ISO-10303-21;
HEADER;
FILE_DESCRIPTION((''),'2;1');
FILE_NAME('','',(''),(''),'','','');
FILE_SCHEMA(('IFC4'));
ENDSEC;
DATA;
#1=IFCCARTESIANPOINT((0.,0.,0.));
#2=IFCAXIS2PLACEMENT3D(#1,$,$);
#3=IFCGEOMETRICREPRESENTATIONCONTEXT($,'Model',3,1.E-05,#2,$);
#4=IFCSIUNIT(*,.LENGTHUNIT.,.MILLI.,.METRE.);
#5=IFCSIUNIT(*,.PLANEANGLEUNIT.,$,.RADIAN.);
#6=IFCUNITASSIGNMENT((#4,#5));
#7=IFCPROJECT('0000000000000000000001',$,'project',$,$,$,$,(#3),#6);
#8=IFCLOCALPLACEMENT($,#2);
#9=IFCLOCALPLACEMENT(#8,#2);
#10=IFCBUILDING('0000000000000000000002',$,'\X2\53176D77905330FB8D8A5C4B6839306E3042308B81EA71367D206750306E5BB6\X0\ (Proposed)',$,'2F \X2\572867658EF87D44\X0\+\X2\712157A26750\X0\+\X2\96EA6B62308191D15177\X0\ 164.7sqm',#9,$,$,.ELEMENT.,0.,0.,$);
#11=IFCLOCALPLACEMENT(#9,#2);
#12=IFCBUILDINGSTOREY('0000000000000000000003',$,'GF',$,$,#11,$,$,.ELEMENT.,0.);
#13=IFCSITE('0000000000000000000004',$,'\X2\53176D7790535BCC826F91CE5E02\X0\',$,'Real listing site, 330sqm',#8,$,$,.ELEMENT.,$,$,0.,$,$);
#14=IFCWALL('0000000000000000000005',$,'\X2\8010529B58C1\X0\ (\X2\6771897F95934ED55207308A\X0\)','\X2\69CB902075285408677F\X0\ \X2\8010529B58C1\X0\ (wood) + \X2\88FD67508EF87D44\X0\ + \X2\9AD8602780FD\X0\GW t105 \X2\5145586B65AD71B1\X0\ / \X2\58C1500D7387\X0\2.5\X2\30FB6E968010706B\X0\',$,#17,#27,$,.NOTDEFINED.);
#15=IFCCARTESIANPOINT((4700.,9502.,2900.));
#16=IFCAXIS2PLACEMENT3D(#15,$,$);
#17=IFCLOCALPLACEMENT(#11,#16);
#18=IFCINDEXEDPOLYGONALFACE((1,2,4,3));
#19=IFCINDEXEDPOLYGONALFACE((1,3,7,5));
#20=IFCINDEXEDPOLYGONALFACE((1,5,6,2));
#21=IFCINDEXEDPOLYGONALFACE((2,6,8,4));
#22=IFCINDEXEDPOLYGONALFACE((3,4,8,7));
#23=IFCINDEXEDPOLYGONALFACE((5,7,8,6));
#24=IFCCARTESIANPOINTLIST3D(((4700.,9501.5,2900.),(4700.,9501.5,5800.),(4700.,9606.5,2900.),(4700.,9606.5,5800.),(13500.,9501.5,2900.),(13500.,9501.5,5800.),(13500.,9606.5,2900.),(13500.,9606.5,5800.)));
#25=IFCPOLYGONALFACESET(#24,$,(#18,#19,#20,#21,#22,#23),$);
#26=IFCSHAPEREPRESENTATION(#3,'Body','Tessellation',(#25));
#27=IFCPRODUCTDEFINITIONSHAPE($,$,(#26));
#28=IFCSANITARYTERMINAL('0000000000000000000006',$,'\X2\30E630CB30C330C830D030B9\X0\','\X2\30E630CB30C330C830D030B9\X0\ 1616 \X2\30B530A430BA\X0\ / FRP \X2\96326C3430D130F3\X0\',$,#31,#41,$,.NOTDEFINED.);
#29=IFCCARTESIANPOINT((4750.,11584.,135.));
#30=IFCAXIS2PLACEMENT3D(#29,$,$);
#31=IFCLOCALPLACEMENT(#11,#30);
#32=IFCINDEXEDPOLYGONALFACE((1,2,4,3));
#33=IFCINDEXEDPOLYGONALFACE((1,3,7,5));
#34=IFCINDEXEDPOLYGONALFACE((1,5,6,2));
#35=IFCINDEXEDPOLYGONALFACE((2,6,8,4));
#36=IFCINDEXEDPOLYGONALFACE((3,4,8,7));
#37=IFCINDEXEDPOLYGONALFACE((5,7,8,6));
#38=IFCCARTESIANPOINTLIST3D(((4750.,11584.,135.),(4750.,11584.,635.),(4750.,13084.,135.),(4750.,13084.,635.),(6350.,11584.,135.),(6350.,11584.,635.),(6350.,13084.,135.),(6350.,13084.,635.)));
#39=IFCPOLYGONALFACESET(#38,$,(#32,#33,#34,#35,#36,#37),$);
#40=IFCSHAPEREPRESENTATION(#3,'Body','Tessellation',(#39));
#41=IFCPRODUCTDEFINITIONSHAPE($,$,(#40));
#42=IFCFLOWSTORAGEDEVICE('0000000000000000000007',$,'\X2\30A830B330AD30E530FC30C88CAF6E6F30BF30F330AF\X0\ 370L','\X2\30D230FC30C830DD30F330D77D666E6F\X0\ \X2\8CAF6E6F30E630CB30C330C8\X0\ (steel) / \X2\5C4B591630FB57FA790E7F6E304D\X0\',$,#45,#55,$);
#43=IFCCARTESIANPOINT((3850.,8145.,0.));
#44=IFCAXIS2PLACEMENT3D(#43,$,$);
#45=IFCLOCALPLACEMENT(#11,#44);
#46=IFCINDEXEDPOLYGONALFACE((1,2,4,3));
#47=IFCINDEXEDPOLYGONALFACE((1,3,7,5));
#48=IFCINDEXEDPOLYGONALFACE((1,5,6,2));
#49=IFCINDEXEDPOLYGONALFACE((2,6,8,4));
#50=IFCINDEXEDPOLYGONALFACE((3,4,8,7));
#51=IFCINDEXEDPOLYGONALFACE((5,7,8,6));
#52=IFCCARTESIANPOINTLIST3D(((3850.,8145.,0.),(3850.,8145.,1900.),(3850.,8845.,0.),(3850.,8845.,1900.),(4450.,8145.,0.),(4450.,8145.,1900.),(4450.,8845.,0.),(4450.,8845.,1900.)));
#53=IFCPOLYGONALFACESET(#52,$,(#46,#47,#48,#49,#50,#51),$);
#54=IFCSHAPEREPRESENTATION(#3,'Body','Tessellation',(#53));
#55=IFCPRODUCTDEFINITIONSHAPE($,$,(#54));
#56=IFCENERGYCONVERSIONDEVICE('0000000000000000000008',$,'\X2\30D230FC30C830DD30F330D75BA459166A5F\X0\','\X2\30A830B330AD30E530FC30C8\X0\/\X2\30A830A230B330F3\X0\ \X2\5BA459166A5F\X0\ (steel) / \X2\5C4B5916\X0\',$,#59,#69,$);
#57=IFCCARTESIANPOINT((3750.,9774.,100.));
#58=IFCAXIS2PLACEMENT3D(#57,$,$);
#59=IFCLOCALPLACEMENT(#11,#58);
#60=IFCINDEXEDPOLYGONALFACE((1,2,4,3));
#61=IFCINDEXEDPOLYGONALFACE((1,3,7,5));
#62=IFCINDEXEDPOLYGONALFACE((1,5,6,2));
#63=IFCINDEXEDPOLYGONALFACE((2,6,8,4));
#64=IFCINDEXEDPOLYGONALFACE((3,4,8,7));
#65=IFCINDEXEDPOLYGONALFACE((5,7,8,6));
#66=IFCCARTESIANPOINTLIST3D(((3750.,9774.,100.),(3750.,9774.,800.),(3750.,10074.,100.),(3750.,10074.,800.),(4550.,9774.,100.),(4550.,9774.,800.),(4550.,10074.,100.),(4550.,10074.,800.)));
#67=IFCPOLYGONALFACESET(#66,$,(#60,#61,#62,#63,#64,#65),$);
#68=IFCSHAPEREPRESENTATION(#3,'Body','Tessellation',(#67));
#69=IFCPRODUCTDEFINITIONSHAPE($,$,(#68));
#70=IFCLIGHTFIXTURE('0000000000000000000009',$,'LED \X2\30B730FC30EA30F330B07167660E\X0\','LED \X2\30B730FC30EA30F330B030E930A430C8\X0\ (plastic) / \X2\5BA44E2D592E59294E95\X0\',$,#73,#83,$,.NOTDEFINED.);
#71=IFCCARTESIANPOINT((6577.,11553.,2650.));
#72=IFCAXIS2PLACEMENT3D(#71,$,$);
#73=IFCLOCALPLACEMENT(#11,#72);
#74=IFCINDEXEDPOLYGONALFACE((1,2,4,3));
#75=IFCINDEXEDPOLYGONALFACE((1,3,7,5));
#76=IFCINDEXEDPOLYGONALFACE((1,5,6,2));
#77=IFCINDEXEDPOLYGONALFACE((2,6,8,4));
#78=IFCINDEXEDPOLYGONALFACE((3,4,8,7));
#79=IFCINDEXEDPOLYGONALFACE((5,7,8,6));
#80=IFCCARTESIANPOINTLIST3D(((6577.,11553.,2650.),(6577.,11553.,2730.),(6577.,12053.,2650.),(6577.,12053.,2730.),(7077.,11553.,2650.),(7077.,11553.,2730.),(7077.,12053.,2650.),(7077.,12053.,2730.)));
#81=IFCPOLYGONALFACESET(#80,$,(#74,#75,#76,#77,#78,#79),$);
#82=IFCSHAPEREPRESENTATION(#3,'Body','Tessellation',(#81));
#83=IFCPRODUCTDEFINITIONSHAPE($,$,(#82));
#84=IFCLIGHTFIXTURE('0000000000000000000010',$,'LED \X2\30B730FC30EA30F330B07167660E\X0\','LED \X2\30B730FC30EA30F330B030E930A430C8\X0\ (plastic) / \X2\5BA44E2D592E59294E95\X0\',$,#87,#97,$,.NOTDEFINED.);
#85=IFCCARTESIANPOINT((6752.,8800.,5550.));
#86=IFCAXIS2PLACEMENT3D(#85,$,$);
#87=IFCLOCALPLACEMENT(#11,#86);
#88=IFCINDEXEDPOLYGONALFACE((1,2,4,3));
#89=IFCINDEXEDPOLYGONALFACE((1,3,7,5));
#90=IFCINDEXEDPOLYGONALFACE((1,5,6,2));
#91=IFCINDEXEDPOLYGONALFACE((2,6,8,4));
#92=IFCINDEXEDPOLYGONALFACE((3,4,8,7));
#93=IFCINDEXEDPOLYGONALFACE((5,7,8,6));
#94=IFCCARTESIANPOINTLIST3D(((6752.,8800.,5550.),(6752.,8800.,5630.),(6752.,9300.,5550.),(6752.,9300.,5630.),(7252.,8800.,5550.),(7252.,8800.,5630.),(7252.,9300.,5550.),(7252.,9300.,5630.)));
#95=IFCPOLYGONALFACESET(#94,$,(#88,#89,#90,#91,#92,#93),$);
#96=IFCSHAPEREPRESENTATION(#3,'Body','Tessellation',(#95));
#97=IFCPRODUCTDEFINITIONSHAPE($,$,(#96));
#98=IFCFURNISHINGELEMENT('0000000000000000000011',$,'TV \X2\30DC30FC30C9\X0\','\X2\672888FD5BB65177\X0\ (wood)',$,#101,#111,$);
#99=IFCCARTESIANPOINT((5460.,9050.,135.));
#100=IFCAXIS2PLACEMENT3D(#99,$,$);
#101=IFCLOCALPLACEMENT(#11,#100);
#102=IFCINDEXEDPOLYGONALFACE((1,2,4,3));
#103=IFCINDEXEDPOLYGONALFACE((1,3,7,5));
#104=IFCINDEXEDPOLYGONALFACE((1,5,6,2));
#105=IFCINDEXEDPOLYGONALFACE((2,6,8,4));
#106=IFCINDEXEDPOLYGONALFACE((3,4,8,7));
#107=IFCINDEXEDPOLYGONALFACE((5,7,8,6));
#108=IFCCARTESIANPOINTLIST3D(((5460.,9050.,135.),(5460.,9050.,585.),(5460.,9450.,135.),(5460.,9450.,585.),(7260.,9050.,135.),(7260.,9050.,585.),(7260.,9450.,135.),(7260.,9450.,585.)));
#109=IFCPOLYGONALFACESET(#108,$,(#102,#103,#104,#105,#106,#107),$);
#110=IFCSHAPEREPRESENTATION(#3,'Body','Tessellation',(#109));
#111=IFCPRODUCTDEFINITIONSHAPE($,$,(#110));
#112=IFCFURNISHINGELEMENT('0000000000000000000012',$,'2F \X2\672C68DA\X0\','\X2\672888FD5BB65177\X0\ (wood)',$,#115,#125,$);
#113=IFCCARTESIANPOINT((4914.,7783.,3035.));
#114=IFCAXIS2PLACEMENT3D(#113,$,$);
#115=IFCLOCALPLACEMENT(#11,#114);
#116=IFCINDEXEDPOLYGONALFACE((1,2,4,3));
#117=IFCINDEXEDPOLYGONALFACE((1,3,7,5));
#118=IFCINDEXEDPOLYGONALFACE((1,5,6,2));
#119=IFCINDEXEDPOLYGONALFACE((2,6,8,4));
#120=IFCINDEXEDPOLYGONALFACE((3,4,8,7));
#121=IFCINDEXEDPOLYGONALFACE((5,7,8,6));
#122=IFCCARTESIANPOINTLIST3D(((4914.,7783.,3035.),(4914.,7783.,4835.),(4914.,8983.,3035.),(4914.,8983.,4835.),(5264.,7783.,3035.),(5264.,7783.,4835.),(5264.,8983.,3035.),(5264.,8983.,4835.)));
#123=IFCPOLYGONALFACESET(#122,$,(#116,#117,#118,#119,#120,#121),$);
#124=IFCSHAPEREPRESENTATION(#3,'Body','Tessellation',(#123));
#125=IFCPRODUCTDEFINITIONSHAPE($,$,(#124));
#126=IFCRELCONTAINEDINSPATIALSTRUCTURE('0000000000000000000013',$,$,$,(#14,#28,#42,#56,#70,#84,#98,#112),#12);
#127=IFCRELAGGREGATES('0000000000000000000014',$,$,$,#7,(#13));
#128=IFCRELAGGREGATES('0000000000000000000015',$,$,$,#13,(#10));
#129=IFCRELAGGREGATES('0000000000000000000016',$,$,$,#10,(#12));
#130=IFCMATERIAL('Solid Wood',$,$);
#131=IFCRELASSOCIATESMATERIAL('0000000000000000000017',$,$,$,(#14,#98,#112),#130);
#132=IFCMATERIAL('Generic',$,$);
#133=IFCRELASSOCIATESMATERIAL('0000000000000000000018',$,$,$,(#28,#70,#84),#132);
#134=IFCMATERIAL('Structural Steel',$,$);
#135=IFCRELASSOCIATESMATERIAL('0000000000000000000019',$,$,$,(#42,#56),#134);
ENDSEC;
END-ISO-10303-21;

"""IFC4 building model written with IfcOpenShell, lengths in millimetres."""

from ifc_helpers import new_model, si_unit, frame, frame_2d, origin, place, context, project, spatial, rectangle, extrude, material, element, save


model = new_model("IFC4")

# Units and contexts
model_context = context("Model", 3, precision=1e-05, world=origin())
ifc_project = project(units=[si_unit("LENGTHUNIT", "METRE", prefix="MILLI"), si_unit("PLANEANGLEUNIT", "RADIAN")], contexts=[model_context])

# Site, building, storey
site_placement = place(None, origin())
site = spatial("IfcSite", under=ifc_project, at=site_placement, Name="北海道富良野市", ObjectType="Real listing site, 330sqm", CompositionType="ELEMENT", RefElevation=0.0)
building_placement = place(site_placement, origin())
building = spatial("IfcBuilding", under=site, at=building_placement, Name="北海道・越屋根のある自然素材の家 (Proposed)", ObjectType="2F 在来軸組+無垢材+雪止め金具 164.7sqm", CompositionType="ELEMENT", ElevationOfRefHeight=0.0, ElevationOfTerrain=0.0)
storey_placement = place(building_placement, origin())
storey = spatial("IfcBuildingStorey", under=building, at=storey_placement, Name="GF", CompositionType="ELEMENT", Elevation=0.0)

# Shared definitions
ifc_material_1 = material(Name="Solid Wood")

# Wall
wall_1_placement = place(storey_placement, frame((4700.0, 9502.0, 2900.0)))
element("IfcWall", 1, at=wall_1_placement, inside=storey, material=ifc_material_1, Name="耐力壁 (東西間仕切り)", Description="構造用合板 耐力壁 (wood) + 製材軸組 + 高性能GW t105 充填断熱 / 壁倍率2.5・準耐火", PredefinedType="NOTDEFINED", context=model_context, shape_type="SweptSolid", body=[
    extrude(rectangle(XDim=8800.0, YDim=105.0, at=frame_2d((4400.0, 52.0))), frame((4700.0, 9502.0, 2900.0)), (0.0, 0.0, 1.0), 2900.0),
])

# Sanitary terminal
ifc_material_2 = material(Name="Generic")
sanitary_terminal_placement = place(storey_placement, frame((4750.0, 11584.0, 135.0)))
element("IfcSanitaryTerminal", 2, at=sanitary_terminal_placement, inside=storey, material=ifc_material_2, Name="ユニットバス", Description="ユニットバス 1616 サイズ / FRP 防水パン", PredefinedType="NOTDEFINED", context=model_context, shape_type="SweptSolid", body=[
    extrude(rectangle(XDim=1600.0, YDim=1500.0, at=frame_2d((800.0, 750.0))), frame((4750.0, 11584.0, 135.0)), (0.0, 0.0, 1.0), 500.0),
])

# Flow storage device
ifc_material_3 = material(Name="Structural Steel")
flow_storage_device_placement = place(storey_placement, frame((3850.0, 8145.0, 0.0)))
element("IfcFlowStorageDevice", 3, at=flow_storage_device_placement, inside=storey, material=ifc_material_3, Name="エコキュート貯湯タンク 370L", Description="ヒートポンプ給湯 貯湯ユニット (steel) / 屋外・基礎置き", context=model_context, shape_type="SweptSolid", body=[
    extrude(rectangle(XDim=600.0, YDim=700.0, at=frame_2d((300.0, 350.0))), frame((3850.0, 8145.0, 0.0)), (0.0, 0.0, 1.0), 1900.0),
])

# Energy conversion device
energy_conversion_device_placement = place(storey_placement, frame((3750.0, 9774.0, 100.0)))
element("IfcEnergyConversionDevice", 4, at=energy_conversion_device_placement, inside=storey, material=ifc_material_3, Name="ヒートポンプ室外機", Description="エコキュート/エアコン 室外機 (steel) / 屋外", context=model_context, shape_type="SweptSolid", body=[
    extrude(rectangle(XDim=800.0, YDim=300.0, at=frame_2d((400.0, 150.0))), frame((3750.0, 9774.0, 100.0)), (0.0, 0.0, 1.0), 700.0),
])

# Light fixtures
light_fixture_1_placement = place(storey_placement, frame((6577.0, 11553.0, 2650.0)))
element("IfcLightFixture", 5, at=light_fixture_1_placement, inside=storey, material=ifc_material_2, Name="LED シーリング照明", Description="LED シーリングライト (plastic) / 室中央天井", PredefinedType="NOTDEFINED", context=model_context, shape_type="SweptSolid", body=[
    extrude(rectangle(XDim=500.0, YDim=500.0, at=frame_2d((250.0, 250.0))), frame((6577.0, 11553.0, 2650.0)), (0.0, 0.0, 1.0), 80.0),
])
light_fixture_2_placement = place(storey_placement, frame((6752.0, 8800.0, 5550.0)))
element("IfcLightFixture", 6, at=light_fixture_2_placement, inside=storey, material=ifc_material_2, Name="LED シーリング照明", Description="LED シーリングライト (plastic) / 室中央天井", PredefinedType="NOTDEFINED", context=model_context, shape_type="SweptSolid", body=[
    extrude(rectangle(XDim=500.0, YDim=500.0, at=frame_2d((250.0, 250.0))), frame((6752.0, 8800.0, 5550.0)), (0.0, 0.0, 1.0), 80.0),
])

# Furnishing elements
furnishing_1_placement = place(storey_placement, frame((5460.0, 9050.0, 135.0)))
element("IfcFurnishingElement", 7, at=furnishing_1_placement, inside=storey, material=ifc_material_1, Name="TV ボード", Description="木製家具 (wood)", context=model_context, shape_type="SweptSolid", body=[
    extrude(rectangle(XDim=1800.0, YDim=400.0, at=frame_2d((900.0, 200.0))), frame((5460.0, 9050.0, 135.0)), (0.0, 0.0, 1.0), 450.0),
])
furnishing_2_placement = place(storey_placement, frame((4914.0, 7783.0, 3035.0)))
element("IfcFurnishingElement", 8, at=furnishing_2_placement, inside=storey, material=ifc_material_1, Name="2F 本棚", Description="木製家具 (wood)", context=model_context, shape_type="SweptSolid", body=[
    extrude(rectangle(XDim=350.0, YDim=1200.0, at=frame_2d((175.0, 600.0))), frame((4914.0, 7783.0, 3035.0)), (0.0, 0.0, 1.0), 1800.0),
])

save(model, "model.ifc")
